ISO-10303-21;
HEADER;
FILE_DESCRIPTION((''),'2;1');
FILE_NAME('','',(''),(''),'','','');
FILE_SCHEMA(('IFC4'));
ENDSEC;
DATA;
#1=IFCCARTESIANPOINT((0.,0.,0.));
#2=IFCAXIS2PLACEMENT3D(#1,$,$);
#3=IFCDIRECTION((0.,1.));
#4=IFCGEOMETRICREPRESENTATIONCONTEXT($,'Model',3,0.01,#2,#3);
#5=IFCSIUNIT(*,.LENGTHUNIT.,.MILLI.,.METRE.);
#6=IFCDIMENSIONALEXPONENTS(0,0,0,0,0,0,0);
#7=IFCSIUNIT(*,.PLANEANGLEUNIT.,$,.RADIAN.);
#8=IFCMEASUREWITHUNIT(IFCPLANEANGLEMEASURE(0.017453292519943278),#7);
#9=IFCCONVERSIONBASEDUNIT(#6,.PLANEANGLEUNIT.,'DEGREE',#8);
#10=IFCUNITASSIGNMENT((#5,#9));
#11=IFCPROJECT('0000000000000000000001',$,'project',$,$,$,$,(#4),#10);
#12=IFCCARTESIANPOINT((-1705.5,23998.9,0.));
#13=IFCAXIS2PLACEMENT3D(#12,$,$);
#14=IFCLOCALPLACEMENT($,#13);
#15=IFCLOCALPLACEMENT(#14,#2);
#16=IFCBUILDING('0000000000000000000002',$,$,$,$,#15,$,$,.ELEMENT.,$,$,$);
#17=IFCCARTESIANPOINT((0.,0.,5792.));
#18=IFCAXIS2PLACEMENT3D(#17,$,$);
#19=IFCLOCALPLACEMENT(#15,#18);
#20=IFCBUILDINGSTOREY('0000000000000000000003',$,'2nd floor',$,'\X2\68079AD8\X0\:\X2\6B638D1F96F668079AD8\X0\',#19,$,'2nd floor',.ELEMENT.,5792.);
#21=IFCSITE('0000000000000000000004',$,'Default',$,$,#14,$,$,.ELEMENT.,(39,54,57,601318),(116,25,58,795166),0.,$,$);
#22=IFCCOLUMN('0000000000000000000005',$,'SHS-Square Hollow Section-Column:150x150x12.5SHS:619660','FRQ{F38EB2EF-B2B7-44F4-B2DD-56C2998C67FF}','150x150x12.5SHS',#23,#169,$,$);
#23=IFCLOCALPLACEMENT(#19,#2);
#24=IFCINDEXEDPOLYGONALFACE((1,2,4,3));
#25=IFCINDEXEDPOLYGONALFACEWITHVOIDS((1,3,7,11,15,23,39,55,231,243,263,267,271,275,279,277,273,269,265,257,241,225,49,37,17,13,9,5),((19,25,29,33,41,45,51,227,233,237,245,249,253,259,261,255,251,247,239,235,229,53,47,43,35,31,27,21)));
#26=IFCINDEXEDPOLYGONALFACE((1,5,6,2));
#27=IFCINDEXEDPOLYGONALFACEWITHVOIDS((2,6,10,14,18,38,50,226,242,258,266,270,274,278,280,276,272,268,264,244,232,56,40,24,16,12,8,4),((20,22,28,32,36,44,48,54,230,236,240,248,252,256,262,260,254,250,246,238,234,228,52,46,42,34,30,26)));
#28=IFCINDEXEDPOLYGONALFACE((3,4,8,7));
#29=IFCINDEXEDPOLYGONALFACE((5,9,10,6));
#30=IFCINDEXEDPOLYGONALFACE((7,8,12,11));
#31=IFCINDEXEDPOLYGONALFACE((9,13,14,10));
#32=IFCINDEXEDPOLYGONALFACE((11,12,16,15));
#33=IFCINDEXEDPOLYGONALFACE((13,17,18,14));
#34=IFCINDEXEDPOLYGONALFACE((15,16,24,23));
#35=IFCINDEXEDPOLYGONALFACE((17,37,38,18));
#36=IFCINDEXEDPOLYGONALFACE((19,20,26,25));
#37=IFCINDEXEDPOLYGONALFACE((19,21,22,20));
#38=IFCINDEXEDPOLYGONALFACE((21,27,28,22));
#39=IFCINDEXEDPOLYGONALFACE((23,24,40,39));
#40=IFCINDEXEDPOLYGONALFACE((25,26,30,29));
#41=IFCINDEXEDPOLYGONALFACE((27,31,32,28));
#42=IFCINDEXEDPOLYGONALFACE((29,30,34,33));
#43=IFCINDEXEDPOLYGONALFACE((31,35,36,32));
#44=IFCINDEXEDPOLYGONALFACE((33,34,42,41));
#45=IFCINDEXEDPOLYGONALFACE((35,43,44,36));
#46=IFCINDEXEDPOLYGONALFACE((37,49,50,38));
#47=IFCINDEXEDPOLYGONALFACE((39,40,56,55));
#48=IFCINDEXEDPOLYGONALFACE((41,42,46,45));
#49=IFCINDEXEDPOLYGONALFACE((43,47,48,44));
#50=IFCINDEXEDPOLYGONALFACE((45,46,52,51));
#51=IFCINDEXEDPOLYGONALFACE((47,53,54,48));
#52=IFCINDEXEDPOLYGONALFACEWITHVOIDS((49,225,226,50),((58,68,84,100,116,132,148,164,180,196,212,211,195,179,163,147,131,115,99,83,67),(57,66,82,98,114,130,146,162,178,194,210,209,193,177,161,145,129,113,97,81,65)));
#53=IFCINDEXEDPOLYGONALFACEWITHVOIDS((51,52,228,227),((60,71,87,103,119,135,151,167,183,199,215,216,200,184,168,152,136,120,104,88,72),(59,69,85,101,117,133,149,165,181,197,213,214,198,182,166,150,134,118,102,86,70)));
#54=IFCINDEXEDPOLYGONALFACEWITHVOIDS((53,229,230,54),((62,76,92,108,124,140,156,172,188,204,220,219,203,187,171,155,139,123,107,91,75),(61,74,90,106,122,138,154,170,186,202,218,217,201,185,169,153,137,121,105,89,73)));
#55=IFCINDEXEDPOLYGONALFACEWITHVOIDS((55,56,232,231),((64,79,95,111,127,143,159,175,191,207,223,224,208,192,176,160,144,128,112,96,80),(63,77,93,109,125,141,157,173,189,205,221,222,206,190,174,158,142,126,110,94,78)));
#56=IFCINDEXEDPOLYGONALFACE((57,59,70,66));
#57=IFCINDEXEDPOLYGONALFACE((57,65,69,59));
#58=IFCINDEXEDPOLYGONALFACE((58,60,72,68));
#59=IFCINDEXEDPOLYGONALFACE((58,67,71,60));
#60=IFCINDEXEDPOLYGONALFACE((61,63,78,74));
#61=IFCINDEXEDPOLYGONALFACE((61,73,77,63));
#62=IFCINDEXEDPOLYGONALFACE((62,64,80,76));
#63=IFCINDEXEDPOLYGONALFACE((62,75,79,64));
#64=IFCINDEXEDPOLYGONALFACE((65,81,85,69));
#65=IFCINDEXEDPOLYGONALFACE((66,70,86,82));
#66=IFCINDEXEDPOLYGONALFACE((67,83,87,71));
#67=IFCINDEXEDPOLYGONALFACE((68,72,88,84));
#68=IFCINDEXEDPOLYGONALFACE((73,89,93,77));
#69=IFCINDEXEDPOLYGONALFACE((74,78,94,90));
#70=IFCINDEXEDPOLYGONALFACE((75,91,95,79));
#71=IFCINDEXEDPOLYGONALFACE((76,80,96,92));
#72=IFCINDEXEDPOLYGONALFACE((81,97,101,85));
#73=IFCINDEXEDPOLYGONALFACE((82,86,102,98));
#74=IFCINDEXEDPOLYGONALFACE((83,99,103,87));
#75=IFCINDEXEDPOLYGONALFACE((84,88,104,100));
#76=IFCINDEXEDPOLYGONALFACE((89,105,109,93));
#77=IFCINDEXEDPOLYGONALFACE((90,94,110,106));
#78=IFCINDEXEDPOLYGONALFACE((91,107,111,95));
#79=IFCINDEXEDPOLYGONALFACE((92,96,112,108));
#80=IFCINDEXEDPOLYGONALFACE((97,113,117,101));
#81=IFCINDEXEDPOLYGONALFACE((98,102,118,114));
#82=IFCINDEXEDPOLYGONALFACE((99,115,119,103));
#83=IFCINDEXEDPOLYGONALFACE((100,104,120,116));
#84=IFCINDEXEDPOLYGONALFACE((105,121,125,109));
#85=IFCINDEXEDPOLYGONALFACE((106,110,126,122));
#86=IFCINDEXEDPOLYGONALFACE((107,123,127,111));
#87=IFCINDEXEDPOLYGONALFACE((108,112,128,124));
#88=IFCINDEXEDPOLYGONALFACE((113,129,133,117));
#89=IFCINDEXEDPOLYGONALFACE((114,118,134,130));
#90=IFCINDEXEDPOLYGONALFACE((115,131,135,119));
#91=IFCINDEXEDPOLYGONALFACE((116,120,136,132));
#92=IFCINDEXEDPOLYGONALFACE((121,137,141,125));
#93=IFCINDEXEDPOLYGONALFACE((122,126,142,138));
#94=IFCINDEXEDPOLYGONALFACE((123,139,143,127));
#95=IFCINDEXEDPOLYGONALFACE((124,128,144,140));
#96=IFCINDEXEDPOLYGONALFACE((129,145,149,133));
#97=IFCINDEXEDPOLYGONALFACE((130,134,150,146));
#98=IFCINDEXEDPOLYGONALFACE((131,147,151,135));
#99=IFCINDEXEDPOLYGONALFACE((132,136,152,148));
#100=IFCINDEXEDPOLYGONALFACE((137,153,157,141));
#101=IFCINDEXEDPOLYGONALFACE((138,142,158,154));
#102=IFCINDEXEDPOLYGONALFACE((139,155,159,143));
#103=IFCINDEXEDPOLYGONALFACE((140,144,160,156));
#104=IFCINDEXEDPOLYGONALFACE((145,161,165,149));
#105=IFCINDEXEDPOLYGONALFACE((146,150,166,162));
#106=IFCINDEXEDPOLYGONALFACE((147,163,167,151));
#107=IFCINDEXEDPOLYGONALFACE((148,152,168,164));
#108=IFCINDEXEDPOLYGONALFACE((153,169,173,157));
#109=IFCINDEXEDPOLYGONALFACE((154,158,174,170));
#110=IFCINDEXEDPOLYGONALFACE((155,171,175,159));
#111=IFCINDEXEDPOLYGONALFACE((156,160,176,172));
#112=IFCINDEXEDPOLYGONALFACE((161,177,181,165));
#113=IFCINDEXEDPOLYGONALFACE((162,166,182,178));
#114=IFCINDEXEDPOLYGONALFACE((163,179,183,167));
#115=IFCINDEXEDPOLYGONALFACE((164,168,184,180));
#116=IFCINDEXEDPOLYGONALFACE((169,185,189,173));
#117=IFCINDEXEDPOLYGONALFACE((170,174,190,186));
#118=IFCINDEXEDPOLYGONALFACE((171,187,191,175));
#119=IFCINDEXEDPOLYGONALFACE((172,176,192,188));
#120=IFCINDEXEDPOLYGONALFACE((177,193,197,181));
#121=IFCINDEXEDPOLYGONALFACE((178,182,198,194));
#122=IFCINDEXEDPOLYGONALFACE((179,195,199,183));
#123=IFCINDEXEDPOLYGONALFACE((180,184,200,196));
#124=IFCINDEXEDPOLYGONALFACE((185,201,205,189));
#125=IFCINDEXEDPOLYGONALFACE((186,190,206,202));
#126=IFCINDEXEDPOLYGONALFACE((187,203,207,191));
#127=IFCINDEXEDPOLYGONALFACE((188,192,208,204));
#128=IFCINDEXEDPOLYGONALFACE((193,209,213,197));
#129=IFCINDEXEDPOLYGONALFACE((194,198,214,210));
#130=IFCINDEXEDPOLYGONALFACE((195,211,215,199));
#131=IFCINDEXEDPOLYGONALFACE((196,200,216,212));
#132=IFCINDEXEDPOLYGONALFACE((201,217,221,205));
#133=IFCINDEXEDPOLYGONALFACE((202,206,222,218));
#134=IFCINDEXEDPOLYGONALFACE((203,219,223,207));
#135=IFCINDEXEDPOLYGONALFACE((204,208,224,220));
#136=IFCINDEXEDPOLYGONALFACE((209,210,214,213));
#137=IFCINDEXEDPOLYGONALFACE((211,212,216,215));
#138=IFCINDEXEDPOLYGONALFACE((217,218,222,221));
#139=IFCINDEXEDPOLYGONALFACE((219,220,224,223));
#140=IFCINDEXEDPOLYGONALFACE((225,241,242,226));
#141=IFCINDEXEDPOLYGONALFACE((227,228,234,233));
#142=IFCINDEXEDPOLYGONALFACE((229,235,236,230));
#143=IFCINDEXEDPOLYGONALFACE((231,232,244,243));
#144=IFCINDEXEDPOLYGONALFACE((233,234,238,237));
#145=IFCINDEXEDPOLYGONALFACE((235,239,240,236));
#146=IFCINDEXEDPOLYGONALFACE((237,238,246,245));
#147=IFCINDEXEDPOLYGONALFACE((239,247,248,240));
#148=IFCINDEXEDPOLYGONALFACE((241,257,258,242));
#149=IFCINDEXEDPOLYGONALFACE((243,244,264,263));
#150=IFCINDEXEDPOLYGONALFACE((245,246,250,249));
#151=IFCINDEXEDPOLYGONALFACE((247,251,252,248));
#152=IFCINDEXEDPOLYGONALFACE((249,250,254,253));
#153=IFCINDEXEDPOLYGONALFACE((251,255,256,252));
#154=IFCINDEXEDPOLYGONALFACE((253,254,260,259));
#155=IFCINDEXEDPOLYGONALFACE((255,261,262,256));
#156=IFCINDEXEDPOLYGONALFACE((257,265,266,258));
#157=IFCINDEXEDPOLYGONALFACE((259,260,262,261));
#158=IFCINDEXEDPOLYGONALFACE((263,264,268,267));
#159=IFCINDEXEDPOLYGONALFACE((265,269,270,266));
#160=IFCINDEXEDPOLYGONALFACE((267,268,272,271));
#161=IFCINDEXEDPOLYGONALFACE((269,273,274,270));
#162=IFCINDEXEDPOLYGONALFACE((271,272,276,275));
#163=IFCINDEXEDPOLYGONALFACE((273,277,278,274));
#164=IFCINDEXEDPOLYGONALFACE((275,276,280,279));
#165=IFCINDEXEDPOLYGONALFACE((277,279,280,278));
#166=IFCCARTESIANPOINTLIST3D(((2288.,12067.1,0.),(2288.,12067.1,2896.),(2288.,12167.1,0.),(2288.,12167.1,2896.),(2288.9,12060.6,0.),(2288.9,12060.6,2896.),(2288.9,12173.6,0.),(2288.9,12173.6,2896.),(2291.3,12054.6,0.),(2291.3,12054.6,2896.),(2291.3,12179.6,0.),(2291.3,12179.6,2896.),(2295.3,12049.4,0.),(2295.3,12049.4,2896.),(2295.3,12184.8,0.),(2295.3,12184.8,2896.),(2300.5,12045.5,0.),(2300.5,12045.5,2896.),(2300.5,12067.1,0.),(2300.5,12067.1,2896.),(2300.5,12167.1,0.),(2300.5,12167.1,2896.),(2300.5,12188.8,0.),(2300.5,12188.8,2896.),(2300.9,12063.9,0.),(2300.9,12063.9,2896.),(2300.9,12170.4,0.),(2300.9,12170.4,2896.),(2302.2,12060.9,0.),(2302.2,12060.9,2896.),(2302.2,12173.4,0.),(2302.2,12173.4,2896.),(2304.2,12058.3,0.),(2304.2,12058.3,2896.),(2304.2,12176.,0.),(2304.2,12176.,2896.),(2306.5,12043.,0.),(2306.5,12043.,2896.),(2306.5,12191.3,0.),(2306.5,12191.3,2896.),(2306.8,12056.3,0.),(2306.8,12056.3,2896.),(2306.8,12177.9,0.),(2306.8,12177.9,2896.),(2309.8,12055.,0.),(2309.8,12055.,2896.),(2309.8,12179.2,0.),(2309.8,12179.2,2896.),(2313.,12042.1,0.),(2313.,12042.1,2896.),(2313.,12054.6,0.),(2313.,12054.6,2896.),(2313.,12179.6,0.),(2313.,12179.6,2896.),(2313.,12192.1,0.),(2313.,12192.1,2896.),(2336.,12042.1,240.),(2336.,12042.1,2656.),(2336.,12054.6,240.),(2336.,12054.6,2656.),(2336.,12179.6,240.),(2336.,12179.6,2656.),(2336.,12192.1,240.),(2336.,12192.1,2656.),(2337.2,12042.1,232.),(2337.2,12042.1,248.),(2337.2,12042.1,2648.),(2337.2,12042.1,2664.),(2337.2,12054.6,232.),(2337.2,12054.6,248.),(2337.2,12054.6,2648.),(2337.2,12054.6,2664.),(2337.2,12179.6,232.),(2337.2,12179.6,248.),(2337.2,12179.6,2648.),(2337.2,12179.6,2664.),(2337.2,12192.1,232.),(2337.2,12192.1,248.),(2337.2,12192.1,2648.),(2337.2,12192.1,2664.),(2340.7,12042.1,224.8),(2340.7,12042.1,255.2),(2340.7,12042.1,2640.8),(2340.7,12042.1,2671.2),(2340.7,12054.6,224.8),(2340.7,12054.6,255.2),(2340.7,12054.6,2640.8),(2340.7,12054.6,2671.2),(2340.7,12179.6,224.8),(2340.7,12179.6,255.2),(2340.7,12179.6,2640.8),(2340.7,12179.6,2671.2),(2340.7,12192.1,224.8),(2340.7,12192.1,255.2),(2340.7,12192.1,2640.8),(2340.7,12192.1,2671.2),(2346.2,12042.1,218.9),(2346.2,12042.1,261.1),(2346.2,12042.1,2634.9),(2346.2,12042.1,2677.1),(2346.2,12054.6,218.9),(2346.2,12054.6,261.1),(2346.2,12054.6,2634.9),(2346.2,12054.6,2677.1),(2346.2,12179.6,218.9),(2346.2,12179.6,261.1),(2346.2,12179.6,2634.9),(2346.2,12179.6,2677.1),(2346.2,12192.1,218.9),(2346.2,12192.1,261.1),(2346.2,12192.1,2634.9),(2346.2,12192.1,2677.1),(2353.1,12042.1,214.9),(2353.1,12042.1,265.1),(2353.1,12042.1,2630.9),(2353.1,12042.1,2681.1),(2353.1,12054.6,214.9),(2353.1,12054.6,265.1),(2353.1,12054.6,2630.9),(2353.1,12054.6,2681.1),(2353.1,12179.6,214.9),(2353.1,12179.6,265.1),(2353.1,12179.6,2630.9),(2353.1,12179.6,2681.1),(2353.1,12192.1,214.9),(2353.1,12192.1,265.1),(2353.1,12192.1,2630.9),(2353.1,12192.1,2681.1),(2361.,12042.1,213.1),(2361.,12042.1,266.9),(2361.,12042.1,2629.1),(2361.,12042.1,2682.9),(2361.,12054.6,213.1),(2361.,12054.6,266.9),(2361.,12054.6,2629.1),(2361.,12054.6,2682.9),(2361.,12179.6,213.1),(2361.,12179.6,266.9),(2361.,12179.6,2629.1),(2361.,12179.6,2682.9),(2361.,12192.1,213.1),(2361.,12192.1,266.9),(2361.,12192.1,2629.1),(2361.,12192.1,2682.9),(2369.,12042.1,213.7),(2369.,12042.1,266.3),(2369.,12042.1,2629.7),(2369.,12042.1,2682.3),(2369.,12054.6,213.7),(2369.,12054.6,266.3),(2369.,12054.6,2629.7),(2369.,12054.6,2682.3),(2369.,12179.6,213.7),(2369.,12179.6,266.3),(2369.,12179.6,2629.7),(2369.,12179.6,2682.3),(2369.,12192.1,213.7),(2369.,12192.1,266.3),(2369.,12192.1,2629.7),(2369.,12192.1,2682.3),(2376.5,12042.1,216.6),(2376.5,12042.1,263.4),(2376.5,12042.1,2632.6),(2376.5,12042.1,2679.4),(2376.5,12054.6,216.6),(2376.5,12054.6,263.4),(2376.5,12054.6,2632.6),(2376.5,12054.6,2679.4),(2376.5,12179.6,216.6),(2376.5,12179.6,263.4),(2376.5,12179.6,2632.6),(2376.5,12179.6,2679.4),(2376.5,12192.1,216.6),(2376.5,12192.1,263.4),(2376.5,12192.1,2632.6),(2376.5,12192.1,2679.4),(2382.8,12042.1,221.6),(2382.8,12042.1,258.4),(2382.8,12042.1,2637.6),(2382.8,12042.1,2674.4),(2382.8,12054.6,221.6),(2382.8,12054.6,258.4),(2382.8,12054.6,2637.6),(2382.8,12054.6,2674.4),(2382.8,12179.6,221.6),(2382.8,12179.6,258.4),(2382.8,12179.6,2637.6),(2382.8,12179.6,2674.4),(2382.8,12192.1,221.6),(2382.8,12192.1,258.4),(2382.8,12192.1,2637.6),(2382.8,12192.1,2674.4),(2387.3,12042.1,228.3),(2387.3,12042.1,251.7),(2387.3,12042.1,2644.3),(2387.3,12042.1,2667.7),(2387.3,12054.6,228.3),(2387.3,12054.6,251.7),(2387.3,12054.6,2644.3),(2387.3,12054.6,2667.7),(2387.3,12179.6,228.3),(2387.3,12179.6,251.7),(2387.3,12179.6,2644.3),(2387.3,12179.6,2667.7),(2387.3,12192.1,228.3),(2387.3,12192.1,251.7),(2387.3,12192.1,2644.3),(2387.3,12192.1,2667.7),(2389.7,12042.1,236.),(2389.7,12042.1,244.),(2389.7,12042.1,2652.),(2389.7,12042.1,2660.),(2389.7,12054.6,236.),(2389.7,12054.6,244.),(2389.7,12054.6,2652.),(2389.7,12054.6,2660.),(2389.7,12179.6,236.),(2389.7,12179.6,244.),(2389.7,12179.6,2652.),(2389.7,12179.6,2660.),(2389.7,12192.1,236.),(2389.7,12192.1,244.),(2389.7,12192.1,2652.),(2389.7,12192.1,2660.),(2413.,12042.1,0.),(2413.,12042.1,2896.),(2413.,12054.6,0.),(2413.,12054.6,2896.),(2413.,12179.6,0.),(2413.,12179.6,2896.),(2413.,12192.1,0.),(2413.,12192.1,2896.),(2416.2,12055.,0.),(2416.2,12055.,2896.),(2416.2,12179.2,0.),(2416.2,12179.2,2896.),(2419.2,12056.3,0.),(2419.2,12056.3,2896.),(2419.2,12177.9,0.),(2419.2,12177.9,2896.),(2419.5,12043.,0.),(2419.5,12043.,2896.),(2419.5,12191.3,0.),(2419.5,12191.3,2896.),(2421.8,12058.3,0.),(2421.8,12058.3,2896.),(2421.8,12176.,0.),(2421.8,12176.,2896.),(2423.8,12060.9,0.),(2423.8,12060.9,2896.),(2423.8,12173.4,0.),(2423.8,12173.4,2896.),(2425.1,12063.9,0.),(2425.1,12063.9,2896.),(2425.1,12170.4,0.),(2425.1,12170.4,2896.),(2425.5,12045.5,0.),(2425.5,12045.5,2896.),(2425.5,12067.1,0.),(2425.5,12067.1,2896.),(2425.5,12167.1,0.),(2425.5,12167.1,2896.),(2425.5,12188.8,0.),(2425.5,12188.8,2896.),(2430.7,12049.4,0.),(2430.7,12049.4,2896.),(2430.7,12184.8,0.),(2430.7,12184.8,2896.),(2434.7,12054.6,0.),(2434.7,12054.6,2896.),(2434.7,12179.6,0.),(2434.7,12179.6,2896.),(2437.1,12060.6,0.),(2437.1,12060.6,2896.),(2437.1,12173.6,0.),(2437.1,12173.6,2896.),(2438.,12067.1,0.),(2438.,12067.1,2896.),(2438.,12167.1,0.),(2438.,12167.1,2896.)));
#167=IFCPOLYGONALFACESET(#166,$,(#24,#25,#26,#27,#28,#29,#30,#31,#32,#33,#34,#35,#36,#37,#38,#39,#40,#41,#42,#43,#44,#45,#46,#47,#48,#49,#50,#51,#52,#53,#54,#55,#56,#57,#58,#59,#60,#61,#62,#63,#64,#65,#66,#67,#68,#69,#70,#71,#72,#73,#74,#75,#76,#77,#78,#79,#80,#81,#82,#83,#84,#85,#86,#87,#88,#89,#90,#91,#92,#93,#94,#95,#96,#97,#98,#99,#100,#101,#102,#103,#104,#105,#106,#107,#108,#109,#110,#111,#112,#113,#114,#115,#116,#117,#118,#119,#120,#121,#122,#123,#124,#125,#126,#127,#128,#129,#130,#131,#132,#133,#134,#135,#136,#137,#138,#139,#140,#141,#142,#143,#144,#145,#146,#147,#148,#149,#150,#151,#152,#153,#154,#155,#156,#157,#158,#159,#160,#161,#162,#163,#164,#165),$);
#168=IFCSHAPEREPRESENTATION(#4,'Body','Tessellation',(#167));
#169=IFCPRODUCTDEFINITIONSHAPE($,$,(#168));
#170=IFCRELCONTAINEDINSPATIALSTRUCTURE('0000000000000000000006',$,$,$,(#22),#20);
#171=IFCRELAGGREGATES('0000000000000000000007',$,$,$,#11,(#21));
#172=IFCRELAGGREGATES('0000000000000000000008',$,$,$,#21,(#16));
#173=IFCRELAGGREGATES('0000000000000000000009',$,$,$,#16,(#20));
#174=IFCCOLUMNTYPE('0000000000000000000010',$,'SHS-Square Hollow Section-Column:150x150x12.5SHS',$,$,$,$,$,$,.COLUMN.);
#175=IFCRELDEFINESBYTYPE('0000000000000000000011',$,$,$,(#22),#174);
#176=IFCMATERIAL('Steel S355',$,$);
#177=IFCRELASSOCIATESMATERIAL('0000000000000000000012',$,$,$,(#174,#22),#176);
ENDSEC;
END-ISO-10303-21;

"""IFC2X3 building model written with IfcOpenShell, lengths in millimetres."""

from ifc_helpers import new_model, entity, si_unit, converted_unit, direction, frame, frame_2d, origin, origin_2d, place, context, project, spatial, circle_curve, hollow_rectangle, outline, extrude, material, type_object, element, save


model = new_model("IFC2X3")

# Units and contexts
model_context = context("Model", 3, precision=0.01, world=origin(), true_north=direction((0.0, 1.0)))
ifc_project = project(units=[si_unit("LENGTHUNIT", "METRE", prefix="MILLI"), converted_unit("PLANEANGLEUNIT", "DEGREE", entity("IfcPlaneAngleMeasure", 0.017453292519943278), si_unit("PLANEANGLEUNIT", "RADIAN"), dimensions=[0, 0, 0, 0, 0, 0, 0])], contexts=[model_context])

# Site, building, storey
site_placement = place(None, frame((-1705.5, 23998.9, 0.0)))
site = spatial("IfcSite", under=ifc_project, at=site_placement, Name="Default", CompositionType="ELEMENT", RefLatitude=(39, 54, 57, 601318), RefLongitude=(116, 25, 58, 795166), RefElevation=0.0)
building_placement = place(site_placement, origin())
building = spatial("IfcBuilding", under=site, at=building_placement, CompositionType="ELEMENT")
storey_placement = place(building_placement, frame((0.0, 0.0, 5792.0)))
storey = spatial("IfcBuildingStorey", under=building, at=storey_placement, Name="2nd floor", ObjectType="标高:正负零标高", LongName="2nd floor", CompositionType="ELEMENT", Elevation=5792.0)

# Column, openings
ifc_material_1 = material(Name="Steel S355")
column_type_1 = type_object("IfcColumnType", Name="SHS-Square Hollow Section-Column:150x150x12.5SHS", PredefinedType="COLUMN", material=ifc_material_1)
column_1_placement = place(storey_placement, frame((2363.0, 12117.1, 2896.0), z_axis=(0.0, 0.0, 1.0), x_axis=(0.0, 1.0, 0.0)))
column_1 = element("IfcColumn", 1, at=column_1_placement, inside=storey, type_object=column_type_1, material=ifc_material_1, Name="SHS-Square Hollow Section-Column:150x150x12.5SHS:619660", Description="FRQ{F38EB2EF-B2B7-44F4-B2DD-56C2998C67FF}", ObjectType="150x150x12.5SHS", context=model_context, shape_type="SweptSolid", body=[
    extrude(hollow_rectangle(XDim=150.0, YDim=150.0, WallThickness=12.5, InnerFilletRadius=12.5, OuterFilletRadius=25.0, at=origin_2d()), origin(), (0.0, 0.0, -1.0), 2896.0),
])
opening_1_placement = place(column_1_placement, frame((-175.1, 0.0, 0.0), z_axis=(1.0, 0.0, 0.0), x_axis=(0.0, 1.0, 0.0)))
element("IfcOpeningElement", 2, at=opening_1_placement, cuts=column_1, ObjectType="Opening", context=model_context, shape_type="SweptSolid", body=[
    extrude(outline(circle_curve(frame_2d((0.0, -240.0), x_axis=(1.0, 0.0)), 27.0)), origin(), (0.0, 0.0, 1.0), 350.2),
])
opening_2_placement = place(column_1_placement, frame((-175.1, 0.0, -2896.0), z_axis=(1.0, 0.0, 0.0), x_axis=(0.0, 1.0, 0.0)))
element("IfcOpeningElement", 3, at=opening_2_placement, cuts=column_1, ObjectType="Opening", context=model_context, shape_type="SweptSolid", body=[
    extrude(outline(circle_curve(frame_2d((0.0, 240.0), x_axis=(1.0, 0.0)), 27.0)), origin(), (0.0, 0.0, 1.0), 350.2),
])

save(model, "model.ifc")
